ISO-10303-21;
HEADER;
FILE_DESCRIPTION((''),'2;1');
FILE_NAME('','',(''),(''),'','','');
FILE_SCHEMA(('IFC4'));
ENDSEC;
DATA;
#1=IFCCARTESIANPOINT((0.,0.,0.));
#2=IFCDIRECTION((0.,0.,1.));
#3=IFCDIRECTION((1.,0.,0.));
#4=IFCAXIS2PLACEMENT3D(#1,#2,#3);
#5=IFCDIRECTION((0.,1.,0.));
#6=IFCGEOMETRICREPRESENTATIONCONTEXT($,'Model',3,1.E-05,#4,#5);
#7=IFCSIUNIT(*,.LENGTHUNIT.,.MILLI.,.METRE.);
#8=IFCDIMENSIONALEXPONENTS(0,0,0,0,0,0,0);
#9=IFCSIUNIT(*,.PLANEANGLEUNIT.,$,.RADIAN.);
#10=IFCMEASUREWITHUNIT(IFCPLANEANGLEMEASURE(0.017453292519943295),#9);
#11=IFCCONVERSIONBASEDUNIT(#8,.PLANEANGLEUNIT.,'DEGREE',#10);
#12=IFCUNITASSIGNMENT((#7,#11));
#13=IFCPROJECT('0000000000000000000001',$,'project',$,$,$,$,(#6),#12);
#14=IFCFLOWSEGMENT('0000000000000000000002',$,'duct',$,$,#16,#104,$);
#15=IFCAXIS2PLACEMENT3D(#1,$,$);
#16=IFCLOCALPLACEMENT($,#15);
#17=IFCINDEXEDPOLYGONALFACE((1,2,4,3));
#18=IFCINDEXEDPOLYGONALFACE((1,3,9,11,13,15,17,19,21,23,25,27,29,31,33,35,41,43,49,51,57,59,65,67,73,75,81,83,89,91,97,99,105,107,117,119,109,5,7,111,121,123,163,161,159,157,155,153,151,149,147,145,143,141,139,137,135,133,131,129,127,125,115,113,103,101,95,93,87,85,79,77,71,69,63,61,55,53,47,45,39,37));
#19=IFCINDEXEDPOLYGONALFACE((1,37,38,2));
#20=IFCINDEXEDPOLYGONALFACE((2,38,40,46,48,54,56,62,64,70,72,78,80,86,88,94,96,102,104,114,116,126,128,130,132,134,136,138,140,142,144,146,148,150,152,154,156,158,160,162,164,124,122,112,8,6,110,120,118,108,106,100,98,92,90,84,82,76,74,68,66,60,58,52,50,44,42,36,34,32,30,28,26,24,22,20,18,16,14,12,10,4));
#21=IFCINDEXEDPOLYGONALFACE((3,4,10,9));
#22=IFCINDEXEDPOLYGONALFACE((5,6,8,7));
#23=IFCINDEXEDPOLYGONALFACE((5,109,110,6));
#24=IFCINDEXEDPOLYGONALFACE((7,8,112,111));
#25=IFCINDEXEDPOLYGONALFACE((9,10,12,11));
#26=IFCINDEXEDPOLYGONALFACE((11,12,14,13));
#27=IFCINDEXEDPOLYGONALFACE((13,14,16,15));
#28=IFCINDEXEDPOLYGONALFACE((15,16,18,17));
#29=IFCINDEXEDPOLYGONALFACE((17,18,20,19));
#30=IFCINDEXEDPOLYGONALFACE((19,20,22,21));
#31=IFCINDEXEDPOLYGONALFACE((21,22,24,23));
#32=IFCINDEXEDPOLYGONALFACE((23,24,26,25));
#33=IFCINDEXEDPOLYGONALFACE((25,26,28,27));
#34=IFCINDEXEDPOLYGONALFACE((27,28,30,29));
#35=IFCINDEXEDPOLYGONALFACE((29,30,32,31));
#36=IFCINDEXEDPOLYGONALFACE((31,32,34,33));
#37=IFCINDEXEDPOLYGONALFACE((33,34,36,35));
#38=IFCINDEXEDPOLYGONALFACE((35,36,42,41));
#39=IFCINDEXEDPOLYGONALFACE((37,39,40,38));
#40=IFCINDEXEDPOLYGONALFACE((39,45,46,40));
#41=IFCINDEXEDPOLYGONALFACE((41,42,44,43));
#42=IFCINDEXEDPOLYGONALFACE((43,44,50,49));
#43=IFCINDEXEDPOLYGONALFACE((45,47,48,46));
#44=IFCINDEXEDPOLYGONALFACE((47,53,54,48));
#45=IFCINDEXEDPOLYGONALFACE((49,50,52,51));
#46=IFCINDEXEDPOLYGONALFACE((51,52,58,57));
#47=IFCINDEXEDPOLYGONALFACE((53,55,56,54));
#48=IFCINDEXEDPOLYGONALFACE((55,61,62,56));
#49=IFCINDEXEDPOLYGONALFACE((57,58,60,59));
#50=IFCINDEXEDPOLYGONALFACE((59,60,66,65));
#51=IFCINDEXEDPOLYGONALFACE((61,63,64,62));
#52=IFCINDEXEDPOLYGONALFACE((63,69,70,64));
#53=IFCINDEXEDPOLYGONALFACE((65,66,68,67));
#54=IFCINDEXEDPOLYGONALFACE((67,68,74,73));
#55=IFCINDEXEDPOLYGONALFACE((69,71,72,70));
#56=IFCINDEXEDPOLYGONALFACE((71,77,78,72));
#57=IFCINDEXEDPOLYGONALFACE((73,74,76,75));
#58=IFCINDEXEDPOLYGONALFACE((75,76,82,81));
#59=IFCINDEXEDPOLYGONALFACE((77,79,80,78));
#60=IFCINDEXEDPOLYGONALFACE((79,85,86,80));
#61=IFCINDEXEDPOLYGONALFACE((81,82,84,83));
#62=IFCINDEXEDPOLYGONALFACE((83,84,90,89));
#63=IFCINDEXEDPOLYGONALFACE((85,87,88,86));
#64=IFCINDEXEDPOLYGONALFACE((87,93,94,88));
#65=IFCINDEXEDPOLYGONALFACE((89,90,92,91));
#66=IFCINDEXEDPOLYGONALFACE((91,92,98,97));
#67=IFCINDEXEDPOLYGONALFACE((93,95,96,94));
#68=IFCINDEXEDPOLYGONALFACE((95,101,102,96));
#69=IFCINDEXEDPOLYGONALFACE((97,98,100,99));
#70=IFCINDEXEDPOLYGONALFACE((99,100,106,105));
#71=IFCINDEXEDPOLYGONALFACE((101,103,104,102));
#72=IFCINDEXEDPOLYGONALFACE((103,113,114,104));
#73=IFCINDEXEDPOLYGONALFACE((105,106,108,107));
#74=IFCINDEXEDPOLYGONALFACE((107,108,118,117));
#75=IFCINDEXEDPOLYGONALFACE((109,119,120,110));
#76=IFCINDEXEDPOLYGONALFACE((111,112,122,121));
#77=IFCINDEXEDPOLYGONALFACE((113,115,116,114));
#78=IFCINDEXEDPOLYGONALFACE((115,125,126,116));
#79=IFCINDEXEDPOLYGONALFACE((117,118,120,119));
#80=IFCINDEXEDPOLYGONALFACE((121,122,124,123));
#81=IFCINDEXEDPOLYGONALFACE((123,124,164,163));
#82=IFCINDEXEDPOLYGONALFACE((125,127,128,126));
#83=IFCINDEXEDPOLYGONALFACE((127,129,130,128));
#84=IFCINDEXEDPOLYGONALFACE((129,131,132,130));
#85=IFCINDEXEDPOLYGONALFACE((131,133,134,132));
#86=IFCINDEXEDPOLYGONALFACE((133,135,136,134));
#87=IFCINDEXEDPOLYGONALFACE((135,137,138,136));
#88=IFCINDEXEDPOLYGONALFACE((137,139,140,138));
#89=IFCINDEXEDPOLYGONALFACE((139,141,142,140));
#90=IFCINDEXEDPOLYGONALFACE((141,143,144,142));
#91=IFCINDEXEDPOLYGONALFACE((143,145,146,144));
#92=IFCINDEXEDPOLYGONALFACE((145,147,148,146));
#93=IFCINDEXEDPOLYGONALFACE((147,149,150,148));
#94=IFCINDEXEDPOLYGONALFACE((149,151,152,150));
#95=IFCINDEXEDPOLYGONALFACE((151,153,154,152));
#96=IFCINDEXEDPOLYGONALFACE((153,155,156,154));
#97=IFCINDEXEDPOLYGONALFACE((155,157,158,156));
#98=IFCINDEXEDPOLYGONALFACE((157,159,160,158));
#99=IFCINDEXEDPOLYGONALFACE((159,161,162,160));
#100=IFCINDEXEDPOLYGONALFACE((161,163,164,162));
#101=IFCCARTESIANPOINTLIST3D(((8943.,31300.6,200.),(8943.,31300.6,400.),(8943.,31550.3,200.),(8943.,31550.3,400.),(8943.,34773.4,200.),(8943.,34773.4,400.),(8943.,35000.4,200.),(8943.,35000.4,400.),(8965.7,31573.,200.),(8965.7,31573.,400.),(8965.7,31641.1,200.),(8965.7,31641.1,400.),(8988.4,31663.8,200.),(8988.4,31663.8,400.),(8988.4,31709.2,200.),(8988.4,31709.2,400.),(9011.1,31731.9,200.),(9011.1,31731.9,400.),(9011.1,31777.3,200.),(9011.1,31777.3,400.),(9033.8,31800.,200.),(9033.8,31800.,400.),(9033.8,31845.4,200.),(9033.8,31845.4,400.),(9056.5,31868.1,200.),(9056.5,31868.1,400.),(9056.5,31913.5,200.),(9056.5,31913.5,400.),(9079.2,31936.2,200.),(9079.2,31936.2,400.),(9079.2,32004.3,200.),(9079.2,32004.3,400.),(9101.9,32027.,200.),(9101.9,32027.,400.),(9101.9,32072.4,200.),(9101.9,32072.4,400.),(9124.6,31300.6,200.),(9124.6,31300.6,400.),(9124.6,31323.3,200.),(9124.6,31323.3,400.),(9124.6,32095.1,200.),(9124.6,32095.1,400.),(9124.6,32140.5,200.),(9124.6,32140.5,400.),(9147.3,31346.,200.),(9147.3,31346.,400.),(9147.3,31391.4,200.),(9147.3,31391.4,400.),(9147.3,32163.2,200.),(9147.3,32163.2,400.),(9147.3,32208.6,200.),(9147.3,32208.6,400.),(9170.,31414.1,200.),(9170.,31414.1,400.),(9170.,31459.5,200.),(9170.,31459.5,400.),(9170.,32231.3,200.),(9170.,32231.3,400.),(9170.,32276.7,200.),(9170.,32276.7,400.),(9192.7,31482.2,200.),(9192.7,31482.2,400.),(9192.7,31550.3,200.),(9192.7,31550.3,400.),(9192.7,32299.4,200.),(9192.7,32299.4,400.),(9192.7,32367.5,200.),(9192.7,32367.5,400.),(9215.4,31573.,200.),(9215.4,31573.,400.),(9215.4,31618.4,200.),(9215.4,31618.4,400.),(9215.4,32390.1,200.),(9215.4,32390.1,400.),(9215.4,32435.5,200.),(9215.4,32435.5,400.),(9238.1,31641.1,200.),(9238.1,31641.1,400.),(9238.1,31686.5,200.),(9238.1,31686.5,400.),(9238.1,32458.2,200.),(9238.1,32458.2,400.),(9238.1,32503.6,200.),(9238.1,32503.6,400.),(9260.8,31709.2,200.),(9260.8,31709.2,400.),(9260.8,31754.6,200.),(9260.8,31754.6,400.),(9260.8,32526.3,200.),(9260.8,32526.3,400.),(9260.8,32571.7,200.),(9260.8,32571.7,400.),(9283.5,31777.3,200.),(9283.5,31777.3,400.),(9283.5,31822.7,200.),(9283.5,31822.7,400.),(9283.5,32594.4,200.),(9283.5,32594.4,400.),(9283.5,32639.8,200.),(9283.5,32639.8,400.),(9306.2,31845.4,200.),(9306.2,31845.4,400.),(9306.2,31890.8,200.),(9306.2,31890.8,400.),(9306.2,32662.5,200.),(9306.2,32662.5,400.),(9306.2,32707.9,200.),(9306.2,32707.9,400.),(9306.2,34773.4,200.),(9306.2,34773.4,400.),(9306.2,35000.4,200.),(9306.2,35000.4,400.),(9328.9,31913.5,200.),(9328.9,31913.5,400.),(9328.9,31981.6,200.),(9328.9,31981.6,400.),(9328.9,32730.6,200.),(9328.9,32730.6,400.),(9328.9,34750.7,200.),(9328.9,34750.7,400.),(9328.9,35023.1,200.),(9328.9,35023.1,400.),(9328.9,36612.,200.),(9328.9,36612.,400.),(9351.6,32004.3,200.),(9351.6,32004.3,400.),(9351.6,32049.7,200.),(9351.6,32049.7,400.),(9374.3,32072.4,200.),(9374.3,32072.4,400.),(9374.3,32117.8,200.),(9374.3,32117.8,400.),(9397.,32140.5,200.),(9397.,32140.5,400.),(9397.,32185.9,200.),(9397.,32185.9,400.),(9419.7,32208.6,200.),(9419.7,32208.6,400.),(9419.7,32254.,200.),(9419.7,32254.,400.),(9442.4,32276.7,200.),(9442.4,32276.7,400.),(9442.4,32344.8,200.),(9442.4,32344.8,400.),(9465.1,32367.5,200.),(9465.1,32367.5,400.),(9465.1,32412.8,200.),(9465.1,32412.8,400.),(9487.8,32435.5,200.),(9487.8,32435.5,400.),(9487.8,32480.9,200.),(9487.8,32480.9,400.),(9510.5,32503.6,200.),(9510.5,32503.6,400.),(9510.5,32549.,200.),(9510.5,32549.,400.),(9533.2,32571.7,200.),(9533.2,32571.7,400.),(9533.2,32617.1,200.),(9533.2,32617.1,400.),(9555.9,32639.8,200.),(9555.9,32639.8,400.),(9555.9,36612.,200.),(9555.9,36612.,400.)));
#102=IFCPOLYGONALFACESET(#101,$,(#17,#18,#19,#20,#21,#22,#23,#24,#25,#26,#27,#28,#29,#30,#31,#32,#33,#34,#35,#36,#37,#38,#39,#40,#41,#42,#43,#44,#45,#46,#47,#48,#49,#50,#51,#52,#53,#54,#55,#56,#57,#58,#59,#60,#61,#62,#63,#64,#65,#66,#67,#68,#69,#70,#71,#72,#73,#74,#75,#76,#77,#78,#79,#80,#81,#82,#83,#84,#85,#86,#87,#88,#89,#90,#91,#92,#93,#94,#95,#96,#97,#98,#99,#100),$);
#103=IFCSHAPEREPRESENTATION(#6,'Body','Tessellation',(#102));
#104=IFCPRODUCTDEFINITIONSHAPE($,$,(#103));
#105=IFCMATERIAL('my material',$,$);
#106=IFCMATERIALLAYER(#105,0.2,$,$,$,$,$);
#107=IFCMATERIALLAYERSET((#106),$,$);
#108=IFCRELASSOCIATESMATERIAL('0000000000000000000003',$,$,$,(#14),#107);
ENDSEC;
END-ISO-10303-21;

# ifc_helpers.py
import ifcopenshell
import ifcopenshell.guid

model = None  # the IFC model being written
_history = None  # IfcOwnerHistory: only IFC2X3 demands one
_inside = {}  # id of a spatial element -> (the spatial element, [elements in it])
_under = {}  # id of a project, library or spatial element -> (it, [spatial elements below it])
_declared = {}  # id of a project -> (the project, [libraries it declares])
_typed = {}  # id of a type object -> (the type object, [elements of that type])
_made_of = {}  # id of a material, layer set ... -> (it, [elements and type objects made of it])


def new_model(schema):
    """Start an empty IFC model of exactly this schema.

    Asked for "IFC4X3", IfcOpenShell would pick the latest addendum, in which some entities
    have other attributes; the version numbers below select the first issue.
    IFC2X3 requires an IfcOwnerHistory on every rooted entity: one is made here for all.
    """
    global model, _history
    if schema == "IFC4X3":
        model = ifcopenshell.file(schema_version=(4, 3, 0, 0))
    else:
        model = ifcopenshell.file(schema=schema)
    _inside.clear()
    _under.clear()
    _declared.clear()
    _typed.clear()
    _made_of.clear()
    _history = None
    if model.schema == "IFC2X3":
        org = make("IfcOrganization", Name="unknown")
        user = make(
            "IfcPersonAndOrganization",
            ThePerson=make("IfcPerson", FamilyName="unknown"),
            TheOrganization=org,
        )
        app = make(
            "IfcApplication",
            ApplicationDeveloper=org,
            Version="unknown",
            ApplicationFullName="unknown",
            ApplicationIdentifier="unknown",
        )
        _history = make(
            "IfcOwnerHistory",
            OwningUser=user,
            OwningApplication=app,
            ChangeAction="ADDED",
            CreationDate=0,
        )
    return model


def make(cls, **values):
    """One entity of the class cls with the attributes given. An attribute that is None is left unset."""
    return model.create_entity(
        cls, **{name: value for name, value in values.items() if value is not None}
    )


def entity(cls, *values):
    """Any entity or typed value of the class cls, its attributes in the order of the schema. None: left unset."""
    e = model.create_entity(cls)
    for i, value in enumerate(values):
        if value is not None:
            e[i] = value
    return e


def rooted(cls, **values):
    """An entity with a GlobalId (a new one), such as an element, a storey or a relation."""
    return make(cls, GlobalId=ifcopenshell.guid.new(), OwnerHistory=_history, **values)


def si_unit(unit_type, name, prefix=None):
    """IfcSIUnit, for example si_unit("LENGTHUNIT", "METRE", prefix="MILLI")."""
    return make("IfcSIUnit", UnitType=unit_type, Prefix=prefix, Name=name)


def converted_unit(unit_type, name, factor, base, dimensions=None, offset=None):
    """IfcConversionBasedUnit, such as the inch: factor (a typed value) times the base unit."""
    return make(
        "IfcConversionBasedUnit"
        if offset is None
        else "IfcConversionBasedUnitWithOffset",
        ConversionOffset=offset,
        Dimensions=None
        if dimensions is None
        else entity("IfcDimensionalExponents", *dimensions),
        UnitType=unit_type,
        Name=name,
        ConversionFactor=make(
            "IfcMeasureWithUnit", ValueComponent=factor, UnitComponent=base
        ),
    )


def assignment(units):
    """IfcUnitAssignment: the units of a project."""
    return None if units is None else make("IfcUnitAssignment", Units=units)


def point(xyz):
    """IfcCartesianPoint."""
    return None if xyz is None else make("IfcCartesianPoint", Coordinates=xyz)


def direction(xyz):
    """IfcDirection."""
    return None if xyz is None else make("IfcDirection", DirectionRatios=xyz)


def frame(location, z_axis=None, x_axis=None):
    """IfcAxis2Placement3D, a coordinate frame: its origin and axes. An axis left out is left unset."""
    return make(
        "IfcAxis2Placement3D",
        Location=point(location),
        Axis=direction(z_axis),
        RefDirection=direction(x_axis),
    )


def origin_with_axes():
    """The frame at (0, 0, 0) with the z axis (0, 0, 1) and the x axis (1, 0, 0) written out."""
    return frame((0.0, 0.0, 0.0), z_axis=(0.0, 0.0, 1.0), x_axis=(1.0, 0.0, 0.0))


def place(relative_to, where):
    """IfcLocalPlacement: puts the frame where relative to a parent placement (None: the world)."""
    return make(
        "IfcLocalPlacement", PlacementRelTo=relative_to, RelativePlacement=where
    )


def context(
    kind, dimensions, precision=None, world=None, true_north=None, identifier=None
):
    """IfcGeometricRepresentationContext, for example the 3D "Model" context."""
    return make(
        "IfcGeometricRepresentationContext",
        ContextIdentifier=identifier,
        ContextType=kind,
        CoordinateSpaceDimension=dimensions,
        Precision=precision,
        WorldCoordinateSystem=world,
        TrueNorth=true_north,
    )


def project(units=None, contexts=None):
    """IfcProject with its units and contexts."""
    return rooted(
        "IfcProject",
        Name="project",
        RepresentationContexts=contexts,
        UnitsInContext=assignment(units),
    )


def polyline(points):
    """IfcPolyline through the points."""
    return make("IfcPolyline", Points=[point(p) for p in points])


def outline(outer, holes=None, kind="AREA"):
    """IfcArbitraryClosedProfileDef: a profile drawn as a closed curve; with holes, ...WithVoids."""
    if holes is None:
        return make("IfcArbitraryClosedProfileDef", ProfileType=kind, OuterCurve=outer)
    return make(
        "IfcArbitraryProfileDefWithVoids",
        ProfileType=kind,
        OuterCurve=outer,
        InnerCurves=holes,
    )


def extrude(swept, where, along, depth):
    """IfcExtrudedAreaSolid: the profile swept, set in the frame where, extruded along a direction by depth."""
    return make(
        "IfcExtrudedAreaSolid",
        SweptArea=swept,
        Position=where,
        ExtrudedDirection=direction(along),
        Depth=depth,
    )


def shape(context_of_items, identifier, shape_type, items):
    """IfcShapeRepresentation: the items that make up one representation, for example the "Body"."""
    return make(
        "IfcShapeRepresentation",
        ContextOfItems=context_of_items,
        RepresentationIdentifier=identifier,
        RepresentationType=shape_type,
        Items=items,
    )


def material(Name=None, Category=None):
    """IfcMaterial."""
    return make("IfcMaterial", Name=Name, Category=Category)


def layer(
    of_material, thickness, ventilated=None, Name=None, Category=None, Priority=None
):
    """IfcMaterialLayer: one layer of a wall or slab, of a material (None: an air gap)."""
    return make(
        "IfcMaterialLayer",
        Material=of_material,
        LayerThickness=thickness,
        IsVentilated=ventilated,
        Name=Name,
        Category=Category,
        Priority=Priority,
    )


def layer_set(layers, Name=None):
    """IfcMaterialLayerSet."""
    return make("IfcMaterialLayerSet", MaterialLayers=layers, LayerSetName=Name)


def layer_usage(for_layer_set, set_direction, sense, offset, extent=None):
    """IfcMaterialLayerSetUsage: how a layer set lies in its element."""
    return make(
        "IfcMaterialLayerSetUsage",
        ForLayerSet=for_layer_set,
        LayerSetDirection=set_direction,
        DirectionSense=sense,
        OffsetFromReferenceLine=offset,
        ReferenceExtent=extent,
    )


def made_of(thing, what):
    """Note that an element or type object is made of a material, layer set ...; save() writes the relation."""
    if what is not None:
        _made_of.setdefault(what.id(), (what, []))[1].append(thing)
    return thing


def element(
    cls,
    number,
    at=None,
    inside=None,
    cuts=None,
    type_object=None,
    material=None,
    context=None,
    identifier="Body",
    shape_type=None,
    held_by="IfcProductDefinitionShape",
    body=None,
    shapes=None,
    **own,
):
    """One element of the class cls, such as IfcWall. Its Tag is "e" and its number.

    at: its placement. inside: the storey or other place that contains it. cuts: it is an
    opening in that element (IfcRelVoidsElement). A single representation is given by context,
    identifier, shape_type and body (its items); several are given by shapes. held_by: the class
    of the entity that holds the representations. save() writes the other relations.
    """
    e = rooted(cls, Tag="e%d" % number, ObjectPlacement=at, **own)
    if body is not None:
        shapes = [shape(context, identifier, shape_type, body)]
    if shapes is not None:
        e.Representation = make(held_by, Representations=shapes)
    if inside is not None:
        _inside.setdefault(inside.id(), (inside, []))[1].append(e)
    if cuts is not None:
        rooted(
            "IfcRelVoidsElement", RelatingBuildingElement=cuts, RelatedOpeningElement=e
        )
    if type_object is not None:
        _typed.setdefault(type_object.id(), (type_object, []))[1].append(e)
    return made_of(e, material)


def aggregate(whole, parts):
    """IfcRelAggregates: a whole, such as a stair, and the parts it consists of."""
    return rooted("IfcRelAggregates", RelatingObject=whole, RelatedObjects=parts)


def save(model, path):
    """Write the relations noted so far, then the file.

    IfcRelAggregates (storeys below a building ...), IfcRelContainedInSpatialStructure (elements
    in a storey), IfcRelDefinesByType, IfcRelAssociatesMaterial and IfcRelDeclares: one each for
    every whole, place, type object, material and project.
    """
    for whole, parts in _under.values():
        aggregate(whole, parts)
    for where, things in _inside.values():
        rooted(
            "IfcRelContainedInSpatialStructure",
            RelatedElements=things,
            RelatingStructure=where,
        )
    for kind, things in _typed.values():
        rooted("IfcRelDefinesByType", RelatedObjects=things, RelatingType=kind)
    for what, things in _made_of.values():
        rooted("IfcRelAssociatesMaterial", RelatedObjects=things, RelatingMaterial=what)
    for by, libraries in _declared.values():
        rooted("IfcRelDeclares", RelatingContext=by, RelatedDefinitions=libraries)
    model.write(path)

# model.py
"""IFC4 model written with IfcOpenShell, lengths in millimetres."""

from ifc_helpers import new_model, entity, si_unit, converted_unit, direction, frame, origin_with_axes, place, context, project, polyline, outline, extrude, material, layer, layer_set, layer_usage, element, save


model = new_model("IFC4")

# Units and contexts
model_context = context("Model", 3, precision=1e-05, world=origin_with_axes(), true_north=direction((0.0, 1.0, 0.0)))
ifc_project = project(units=[si_unit("LENGTHUNIT", "METRE", prefix="MILLI"), converted_unit("PLANEANGLEUNIT", "DEGREE", entity("IfcPlaneAngleMeasure", 0.017453292519943295), si_unit("PLANEANGLEUNIT", "RADIAN"), dimensions=[0, 0, 0, 0, 0, 0, 0])], contexts=[model_context])

# Flow segment
ifc_material_1 = material(Name="my material")
ifc_layer_1 = layer(ifc_material_1, 0.2)
ifc_layer_set_1 = layer_set([ifc_layer_1])
ifc_layer_usage_1 = layer_usage(ifc_layer_set_1, "AXIS2", "POSITIVE", -0.1)
flow_segment_1_placement = place(None, origin_with_axes())
element("IfcFlowSegment", 1, at=flow_segment_1_placement, material=ifc_layer_usage_1, Name="duct", context=model_context, shape_type="SweptSolid", body=[
    extrude(outline(polyline([(8943.0, 31300.6), (9124.6, 31300.6), (9124.6, 31323.3), (9147.3, 31346.0), (9147.3, 31391.4), (9170.0, 31414.1), (9170.0, 31459.5), (9192.7, 31482.2), (9192.7, 31550.3), (9215.4, 31573.0), (9215.4, 31618.4), (9238.1, 31641.1), (9238.1, 31686.5), (9260.8, 31709.2), (9260.8, 31754.6), (9283.5, 31777.3), (9283.5, 31822.7), (9306.2, 31845.4), (9306.2, 31890.8), (9328.9, 31913.5), (9328.9, 31981.6), (9351.6, 32004.3), (9351.6, 32049.7), (9374.3, 32072.4), (9374.3, 32117.8), (9397.0, 32140.5), (9397.0, 32185.9), (9419.7, 32208.6), (9419.7, 32254.0), (9442.4, 32276.7), (9442.4, 32344.8), (9465.1, 32367.5), (9465.1, 32412.8), (9487.8, 32435.5), (9487.8, 32480.9), (9510.5, 32503.6), (9510.5, 32549.0), (9533.2, 32571.7), (9533.2, 32617.1), (9555.9, 32639.8), (9555.9, 36612.0), (9328.9, 36612.0), (9328.9, 35023.1), (9306.2, 35000.4), (8943.0, 35000.4), (8943.0, 34773.4), (9306.2, 34773.4), (9328.9, 34750.7), (9328.9, 32730.6), (9306.2, 32707.9), (9306.2, 32662.5), (9283.5, 32639.8), (9283.5, 32594.4), (9260.8, 32571.7), (9260.8, 32526.3), (9238.1, 32503.6), (9238.1, 32458.2), (9215.4, 32435.5), (9215.4, 32390.1), (9192.7, 32367.5), (9192.7, 32299.4), (9170.0, 32276.7), (9170.0, 32231.3), (9147.3, 32208.6), (9147.3, 32163.2), (9124.6, 32140.5), (9124.6, 32095.1), (9101.9, 32072.4), (9101.9, 32027.0), (9079.2, 32004.3), (9079.2, 31936.2), (9056.5, 31913.5), (9056.5, 31868.1), (9033.8, 31845.4), (9033.8, 31800.0), (9011.1, 31777.3), (9011.1, 31731.9), (8988.4, 31709.2), (8988.4, 31663.8), (8965.7, 31641.1), (8965.7, 31573.0), (8943.0, 31550.3), (8943.0, 31300.6)])), frame((0.0, 0.0, 200.0), z_axis=(0.0, 0.0, 1.0), x_axis=(1.0, 0.0, 0.0)), (0.0, 0.0, 1.0), 200.0),
])

save(model, "model.ifc")
